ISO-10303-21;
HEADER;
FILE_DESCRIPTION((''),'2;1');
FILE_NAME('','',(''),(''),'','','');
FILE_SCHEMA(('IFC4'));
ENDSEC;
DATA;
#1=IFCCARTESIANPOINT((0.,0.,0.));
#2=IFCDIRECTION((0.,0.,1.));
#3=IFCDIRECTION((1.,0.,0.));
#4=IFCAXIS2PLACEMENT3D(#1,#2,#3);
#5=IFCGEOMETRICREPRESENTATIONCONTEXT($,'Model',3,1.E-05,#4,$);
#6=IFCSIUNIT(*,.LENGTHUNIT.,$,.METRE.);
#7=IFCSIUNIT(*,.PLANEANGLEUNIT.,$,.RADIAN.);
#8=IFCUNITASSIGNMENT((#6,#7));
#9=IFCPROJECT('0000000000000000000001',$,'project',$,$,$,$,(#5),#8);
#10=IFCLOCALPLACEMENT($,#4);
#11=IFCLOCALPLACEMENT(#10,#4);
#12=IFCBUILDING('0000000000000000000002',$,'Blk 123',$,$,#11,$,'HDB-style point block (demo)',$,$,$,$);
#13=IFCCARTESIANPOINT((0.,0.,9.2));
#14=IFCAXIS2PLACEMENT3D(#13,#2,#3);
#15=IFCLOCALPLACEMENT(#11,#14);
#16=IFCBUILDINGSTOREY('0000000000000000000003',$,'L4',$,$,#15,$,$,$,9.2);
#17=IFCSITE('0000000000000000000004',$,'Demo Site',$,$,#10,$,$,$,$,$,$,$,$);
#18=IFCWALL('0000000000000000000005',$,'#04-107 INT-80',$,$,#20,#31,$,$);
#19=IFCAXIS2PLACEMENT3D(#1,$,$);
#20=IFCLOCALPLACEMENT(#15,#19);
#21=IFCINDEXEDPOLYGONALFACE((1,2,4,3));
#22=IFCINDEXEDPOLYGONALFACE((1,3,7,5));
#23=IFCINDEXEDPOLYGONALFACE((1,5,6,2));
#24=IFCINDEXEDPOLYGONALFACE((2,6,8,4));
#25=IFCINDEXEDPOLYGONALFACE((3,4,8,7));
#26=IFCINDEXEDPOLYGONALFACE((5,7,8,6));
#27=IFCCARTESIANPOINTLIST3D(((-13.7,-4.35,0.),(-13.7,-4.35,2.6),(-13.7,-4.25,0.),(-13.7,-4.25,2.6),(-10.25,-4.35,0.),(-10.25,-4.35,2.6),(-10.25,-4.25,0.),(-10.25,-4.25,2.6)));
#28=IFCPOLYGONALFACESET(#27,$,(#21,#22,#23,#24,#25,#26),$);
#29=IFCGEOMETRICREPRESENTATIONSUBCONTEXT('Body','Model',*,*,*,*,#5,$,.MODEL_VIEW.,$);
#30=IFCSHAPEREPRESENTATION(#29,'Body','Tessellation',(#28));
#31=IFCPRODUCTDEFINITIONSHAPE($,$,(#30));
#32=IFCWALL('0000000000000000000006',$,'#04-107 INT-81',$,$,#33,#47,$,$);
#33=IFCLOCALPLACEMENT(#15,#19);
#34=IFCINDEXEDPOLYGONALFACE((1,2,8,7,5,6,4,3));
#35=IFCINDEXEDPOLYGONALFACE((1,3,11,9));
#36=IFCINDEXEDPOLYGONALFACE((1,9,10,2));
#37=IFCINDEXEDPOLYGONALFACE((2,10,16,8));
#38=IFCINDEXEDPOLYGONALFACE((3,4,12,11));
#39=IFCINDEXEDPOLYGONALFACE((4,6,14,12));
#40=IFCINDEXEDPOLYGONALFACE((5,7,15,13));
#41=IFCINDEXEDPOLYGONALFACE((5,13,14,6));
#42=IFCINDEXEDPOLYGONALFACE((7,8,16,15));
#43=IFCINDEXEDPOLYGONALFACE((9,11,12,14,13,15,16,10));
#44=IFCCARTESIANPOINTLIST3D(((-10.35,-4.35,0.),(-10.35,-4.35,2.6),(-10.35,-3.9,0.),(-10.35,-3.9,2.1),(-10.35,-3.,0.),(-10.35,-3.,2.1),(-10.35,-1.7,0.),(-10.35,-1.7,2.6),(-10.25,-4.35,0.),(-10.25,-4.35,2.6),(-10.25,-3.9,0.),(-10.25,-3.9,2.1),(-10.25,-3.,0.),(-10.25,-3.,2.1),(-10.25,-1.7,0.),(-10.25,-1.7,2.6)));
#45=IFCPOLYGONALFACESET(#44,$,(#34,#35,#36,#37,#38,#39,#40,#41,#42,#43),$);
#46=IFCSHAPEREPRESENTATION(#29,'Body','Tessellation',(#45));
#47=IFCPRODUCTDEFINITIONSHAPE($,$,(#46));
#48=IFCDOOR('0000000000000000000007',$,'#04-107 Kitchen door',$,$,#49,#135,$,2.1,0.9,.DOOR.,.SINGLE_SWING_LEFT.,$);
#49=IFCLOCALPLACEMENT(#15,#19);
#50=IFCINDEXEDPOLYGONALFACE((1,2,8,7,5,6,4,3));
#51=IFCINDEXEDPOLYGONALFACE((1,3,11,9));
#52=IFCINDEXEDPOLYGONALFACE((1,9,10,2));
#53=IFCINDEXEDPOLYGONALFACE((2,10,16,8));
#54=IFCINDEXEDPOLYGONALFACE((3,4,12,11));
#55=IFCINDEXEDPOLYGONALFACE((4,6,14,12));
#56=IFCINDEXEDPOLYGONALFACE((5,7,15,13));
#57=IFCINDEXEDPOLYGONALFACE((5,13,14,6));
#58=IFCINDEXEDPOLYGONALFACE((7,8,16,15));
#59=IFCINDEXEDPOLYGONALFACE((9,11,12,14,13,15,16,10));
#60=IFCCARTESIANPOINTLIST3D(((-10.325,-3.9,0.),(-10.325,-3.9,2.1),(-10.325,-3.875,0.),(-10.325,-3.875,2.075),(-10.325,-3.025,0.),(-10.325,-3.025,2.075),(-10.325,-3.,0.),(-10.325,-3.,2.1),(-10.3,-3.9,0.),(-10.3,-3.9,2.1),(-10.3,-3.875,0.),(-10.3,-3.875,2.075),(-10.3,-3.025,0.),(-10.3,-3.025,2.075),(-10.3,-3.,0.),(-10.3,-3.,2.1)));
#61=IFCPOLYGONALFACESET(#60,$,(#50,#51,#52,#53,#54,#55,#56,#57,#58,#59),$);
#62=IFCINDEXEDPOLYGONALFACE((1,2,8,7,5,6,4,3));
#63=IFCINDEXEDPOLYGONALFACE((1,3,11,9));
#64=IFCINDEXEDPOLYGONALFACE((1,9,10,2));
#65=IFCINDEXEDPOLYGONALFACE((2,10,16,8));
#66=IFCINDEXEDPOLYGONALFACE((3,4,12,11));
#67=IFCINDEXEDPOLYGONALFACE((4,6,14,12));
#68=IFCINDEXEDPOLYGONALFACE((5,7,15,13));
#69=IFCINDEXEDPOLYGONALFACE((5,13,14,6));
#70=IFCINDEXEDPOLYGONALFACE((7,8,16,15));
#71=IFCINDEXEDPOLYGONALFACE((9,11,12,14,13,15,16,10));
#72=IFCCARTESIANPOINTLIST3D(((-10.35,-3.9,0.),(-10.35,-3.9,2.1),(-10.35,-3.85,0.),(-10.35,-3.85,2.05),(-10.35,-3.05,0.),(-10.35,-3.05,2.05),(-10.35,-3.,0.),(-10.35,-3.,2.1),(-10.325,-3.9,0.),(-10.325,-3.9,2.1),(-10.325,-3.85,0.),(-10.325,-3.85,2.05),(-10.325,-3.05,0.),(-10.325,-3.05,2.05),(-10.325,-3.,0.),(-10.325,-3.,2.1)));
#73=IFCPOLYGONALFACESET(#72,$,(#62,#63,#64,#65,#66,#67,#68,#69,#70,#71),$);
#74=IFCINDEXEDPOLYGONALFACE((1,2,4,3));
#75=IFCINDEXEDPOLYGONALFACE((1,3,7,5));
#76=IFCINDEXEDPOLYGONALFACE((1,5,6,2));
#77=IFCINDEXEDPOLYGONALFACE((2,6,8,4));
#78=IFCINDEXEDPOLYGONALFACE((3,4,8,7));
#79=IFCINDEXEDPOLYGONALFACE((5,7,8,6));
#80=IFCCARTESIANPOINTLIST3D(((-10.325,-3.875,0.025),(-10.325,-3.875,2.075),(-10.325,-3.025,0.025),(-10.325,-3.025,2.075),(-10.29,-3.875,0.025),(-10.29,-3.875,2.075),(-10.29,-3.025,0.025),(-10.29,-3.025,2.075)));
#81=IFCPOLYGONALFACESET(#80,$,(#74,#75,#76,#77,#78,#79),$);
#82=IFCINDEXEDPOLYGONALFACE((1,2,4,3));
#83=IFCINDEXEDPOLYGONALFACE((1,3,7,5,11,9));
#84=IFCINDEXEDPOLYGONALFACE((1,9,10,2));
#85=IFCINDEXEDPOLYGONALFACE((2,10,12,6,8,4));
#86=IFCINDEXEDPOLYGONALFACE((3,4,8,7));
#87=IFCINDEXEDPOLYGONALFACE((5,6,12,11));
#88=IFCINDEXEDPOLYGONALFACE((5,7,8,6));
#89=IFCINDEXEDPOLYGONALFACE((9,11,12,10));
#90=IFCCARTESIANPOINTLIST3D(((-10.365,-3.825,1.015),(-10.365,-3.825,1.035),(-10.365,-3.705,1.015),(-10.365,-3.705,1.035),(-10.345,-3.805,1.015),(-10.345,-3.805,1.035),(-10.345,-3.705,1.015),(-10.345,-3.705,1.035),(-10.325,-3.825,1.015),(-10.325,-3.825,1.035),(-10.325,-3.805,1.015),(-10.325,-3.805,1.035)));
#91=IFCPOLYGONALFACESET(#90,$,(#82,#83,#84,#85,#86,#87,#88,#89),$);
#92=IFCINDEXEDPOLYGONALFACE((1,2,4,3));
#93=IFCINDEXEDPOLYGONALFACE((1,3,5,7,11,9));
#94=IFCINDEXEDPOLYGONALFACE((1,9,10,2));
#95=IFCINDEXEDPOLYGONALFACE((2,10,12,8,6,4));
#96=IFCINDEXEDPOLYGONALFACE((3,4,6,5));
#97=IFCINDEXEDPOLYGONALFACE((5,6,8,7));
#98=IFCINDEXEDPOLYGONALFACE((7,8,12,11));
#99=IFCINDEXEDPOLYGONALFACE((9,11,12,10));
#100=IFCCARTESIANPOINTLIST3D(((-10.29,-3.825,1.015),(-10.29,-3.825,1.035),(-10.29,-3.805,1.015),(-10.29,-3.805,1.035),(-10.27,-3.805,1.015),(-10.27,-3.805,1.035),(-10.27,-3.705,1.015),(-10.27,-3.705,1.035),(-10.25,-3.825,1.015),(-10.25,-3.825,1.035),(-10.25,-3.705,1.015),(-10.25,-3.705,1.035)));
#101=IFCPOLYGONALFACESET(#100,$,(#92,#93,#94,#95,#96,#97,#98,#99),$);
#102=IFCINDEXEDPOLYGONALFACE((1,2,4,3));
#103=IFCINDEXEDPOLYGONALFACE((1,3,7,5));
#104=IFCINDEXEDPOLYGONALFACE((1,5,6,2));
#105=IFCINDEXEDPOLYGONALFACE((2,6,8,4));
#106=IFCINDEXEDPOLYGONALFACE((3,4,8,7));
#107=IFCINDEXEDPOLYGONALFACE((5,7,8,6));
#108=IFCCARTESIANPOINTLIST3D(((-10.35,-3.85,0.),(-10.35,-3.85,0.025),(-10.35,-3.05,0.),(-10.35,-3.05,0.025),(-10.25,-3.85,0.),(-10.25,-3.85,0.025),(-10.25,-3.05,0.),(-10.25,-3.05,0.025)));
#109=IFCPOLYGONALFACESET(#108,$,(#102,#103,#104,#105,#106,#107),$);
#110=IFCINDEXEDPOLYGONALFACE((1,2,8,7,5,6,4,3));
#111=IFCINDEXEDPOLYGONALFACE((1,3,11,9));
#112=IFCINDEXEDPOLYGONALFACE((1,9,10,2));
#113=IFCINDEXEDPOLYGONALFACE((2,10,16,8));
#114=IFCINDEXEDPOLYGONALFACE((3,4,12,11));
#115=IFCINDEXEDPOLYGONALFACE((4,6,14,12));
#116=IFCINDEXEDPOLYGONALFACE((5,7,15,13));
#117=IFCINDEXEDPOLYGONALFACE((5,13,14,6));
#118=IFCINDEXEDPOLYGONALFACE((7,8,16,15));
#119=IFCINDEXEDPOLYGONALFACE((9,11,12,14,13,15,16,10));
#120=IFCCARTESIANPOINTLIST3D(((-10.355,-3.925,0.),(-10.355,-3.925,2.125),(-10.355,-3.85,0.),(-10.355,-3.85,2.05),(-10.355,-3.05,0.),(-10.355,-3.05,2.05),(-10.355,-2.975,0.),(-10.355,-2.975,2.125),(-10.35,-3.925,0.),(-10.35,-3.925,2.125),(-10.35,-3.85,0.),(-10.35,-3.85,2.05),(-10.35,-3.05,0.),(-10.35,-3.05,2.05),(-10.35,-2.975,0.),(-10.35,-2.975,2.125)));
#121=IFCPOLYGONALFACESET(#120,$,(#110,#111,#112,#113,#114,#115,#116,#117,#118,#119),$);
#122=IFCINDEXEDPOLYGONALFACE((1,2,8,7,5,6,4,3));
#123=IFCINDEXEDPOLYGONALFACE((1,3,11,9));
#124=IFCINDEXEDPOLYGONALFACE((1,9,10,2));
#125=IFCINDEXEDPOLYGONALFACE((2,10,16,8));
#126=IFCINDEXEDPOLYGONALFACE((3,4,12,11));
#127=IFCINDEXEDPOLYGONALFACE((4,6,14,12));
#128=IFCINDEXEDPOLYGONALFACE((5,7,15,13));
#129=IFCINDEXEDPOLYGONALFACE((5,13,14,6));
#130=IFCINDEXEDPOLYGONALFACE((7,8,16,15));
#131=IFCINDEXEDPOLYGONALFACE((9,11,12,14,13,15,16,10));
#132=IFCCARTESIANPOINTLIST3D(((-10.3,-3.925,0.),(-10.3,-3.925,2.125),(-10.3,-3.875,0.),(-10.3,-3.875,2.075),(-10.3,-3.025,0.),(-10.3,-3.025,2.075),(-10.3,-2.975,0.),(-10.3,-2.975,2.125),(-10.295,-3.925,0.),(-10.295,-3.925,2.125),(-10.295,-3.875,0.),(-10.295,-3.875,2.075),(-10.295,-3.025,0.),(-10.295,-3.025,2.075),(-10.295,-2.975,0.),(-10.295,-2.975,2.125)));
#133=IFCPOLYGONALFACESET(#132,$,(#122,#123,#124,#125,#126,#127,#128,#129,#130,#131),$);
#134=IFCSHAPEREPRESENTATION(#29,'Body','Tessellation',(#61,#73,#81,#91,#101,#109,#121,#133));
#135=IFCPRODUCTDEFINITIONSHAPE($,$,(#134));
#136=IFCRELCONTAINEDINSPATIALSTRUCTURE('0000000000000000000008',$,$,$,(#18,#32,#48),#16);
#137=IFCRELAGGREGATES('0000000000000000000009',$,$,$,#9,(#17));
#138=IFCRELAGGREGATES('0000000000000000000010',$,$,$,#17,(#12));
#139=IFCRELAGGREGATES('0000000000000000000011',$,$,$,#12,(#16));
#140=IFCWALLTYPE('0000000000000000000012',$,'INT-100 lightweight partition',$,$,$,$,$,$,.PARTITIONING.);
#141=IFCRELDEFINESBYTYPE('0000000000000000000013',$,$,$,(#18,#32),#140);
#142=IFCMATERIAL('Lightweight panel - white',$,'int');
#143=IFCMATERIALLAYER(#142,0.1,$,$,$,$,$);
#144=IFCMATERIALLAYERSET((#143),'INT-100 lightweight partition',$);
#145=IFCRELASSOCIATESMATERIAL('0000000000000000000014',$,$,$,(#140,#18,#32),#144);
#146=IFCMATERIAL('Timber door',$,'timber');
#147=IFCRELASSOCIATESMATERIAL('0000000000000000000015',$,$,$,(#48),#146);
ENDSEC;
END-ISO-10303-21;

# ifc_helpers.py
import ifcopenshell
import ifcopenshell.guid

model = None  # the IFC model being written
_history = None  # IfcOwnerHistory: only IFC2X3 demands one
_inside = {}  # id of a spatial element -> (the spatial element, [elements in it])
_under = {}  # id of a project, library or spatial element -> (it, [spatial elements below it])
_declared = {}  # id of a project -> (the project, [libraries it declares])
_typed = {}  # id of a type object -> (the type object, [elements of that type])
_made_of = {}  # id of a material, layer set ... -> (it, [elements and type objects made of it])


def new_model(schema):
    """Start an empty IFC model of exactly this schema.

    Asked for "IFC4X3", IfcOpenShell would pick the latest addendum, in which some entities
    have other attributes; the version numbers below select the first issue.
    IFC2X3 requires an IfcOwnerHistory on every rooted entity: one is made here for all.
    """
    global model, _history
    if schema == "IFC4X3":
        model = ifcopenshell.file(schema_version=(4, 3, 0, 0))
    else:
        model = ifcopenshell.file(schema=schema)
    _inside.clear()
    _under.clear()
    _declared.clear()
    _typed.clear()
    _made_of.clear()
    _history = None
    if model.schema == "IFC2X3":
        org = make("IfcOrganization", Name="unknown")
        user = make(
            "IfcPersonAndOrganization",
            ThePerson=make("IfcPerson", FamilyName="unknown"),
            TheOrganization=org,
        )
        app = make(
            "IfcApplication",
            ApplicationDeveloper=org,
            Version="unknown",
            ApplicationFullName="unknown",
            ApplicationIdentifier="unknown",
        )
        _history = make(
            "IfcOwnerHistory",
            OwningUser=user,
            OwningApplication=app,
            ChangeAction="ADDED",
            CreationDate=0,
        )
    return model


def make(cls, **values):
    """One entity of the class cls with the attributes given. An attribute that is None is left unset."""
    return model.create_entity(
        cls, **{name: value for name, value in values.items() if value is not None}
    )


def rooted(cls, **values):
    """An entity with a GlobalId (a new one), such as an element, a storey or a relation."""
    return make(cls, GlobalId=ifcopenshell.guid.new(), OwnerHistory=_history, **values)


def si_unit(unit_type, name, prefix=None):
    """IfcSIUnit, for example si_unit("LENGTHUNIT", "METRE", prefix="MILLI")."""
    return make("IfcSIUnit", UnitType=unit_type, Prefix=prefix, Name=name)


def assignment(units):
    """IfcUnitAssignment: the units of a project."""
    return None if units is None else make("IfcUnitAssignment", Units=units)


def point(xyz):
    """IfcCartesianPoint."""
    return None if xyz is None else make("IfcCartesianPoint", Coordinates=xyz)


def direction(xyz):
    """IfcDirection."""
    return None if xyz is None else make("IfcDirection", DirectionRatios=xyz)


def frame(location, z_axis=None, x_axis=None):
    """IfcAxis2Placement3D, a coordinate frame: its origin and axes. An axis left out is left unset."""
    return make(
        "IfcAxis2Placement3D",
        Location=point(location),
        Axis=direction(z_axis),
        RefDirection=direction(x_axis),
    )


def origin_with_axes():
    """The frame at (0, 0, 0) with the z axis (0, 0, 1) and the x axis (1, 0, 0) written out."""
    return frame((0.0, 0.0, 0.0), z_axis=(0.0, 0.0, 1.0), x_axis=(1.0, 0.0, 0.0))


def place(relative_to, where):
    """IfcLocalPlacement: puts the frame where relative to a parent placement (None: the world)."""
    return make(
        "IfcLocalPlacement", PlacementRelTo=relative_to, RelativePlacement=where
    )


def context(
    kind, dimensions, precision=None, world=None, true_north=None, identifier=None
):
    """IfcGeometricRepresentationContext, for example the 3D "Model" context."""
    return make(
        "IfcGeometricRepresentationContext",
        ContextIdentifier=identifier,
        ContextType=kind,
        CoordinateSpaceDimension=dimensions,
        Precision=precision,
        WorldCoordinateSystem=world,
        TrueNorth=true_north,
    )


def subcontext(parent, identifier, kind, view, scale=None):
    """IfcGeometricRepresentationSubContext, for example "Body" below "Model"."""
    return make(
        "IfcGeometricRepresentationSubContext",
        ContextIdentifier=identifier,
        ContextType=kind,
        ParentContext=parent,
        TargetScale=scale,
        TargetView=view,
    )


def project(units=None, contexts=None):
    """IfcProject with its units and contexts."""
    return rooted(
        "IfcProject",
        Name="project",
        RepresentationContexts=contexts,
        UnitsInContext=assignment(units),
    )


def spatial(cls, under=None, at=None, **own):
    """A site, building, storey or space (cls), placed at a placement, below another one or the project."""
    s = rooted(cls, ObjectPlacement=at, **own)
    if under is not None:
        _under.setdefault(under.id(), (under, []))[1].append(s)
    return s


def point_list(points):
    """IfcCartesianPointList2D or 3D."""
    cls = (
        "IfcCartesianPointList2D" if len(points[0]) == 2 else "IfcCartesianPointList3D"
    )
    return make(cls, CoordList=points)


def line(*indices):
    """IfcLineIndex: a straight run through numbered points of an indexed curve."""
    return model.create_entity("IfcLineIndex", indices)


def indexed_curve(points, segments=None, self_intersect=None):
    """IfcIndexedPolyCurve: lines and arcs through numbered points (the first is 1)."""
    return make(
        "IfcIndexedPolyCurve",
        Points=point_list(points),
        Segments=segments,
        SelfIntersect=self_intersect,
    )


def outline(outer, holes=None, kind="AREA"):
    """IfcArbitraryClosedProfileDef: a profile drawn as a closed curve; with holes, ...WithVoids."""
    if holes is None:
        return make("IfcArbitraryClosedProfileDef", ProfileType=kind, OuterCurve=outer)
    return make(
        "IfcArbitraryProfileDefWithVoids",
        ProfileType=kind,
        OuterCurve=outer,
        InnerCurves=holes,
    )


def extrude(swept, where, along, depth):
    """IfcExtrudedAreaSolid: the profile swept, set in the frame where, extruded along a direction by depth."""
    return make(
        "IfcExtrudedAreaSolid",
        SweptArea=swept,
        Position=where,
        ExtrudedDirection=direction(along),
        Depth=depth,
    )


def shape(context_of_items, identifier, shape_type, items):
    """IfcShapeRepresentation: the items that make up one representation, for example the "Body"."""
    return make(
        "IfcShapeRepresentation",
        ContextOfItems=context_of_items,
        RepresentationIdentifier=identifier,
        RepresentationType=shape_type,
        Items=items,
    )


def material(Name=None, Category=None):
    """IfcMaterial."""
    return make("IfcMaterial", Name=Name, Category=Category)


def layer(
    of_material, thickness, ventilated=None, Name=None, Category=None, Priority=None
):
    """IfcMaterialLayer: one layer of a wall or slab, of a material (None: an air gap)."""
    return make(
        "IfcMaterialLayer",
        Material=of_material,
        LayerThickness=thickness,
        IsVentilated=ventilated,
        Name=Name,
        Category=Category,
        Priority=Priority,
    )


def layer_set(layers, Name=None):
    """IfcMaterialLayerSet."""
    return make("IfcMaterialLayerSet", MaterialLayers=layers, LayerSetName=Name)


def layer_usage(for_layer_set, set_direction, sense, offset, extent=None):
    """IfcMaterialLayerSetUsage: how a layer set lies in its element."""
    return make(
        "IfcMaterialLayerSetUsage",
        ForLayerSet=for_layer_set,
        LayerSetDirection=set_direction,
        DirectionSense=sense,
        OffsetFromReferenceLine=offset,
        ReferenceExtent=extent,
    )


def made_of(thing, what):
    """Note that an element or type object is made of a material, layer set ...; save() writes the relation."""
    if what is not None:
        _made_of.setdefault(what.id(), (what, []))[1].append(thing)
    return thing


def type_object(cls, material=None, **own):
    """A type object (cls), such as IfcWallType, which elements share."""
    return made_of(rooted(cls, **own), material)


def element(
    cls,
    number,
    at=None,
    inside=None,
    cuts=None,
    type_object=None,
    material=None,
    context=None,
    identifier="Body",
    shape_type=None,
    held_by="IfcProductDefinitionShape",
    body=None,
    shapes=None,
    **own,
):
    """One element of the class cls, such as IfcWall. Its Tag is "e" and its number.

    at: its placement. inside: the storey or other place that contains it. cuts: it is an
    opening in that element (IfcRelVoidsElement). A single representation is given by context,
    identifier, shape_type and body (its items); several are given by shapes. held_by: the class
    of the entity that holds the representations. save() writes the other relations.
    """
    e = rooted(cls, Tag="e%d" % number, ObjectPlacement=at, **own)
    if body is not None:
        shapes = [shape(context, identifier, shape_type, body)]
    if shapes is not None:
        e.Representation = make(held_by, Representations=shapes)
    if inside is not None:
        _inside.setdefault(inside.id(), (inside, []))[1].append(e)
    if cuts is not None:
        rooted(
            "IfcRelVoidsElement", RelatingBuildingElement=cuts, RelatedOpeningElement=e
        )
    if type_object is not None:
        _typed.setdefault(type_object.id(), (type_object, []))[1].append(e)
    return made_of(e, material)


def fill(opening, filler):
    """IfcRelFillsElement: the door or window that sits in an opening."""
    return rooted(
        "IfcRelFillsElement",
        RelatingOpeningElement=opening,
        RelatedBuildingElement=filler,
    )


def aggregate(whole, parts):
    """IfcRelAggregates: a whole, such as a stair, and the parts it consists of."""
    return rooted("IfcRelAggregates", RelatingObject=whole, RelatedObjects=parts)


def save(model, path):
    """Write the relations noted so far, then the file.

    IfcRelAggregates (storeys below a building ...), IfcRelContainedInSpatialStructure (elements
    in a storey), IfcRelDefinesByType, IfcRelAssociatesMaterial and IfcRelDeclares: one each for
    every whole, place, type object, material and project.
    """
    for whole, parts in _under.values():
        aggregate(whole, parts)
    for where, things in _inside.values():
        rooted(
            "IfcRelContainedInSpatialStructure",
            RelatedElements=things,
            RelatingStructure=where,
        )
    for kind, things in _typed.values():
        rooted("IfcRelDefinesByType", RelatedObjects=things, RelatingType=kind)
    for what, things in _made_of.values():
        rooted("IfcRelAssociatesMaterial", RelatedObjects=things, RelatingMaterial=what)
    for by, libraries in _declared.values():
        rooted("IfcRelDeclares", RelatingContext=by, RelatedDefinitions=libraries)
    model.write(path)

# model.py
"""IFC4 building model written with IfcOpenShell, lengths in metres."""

from ifc_helpers import new_model, si_unit, frame, origin_with_axes, place, context, subcontext, project, spatial, line, indexed_curve, outline, extrude, material, layer, layer_set, layer_usage, type_object, element, fill, save


model = new_model("IFC4")

# Units and contexts
model_context = context("Model", 3, precision=1e-05, world=origin_with_axes())
body_context = subcontext(model_context, "Body", "Model", "MODEL_VIEW")
ifc_project = project(units=[si_unit("LENGTHUNIT", "METRE"), si_unit("PLANEANGLEUNIT", "RADIAN")], contexts=[model_context])

# Site, building, storey
site_placement = place(None, origin_with_axes())
site = spatial("IfcSite", under=ifc_project, at=site_placement, Name="Demo Site")
building_placement = place(site_placement, origin_with_axes())
building = spatial("IfcBuilding", under=site, at=building_placement, Name="Blk 123", LongName="HDB-style point block (demo)")
storey_placement = place(building_placement, frame((0.0, 0.0, 9.2), z_axis=(0.0, 0.0, 1.0), x_axis=(1.0, 0.0, 0.0)))
storey = spatial("IfcBuildingStorey", under=building, at=storey_placement, Name="L4", Elevation=9.2)

# Wall
ifc_material_1 = material(Name="Lightweight panel - white", Category="int")
ifc_layer_1 = layer(ifc_material_1, 0.1)
ifc_layer_set_1 = layer_set([ifc_layer_1], Name="INT-100 lightweight partition")
ifc_layer_usage_1 = layer_usage(ifc_layer_set_1, "AXIS2", "POSITIVE", -0.05)
wall_type_1 = type_object("IfcWallType", Name="INT-100 lightweight partition", PredefinedType="PARTITIONING", material=ifc_layer_set_1)
wall_1_placement = place(storey_placement, frame((-10.25, -4.3, 0.0), z_axis=(0.0, 0.0, 1.0), x_axis=(-1.0, 0.0, 0.0)))
element("IfcWall", 1, at=wall_1_placement, inside=storey, type_object=wall_type_1, material=ifc_layer_usage_1, Name="#04-107 INT-80", context=body_context, shape_type="SweptSolid", body=[
    extrude(outline(indexed_curve([(0.0, 0.0), (0.0, 0.1), (3.45, 0.1), (3.45, 0.0), (0.0, 0.0)], self_intersect=False)), frame((0.0, -0.05, 0.0), z_axis=(0.0, 0.0, 1.0), x_axis=(1.0, 0.0, 0.0)), (0.0, 0.0, 1.0), 2.6),
])

# Wall, opening, door
wall_2_placement = place(storey_placement, frame((-10.3, -1.7, 0.0), z_axis=(0.0, 0.0, 1.0), x_axis=(0.0, -1.0, 0.0)))
wall_2 = element("IfcWall", 2, at=wall_2_placement, inside=storey, type_object=wall_type_1, material=ifc_layer_usage_1, Name="#04-107 INT-81", context=body_context, shape_type="SweptSolid", body=[
    extrude(outline(indexed_curve([(0.0, 0.0), (0.0, 0.1), (2.65, 0.1), (2.65, 0.0), (0.0, 0.0)], self_intersect=False)), frame((0.0, -0.05, 0.0), z_axis=(0.0, 0.0, 1.0), x_axis=(1.0, 0.0, 0.0)), (0.0, 0.0, 1.0), 2.6),
])
opening_1_placement = place(wall_2_placement, frame((1.3, -0.15, 0.0), z_axis=(0.0, 0.0, 1.0), x_axis=(1.0, 0.0, 0.0)))
opening_1 = element("IfcOpeningElement", 3, at=opening_1_placement, cuts=wall_2, context=body_context, shape_type="SweptSolid", body=[
    extrude(outline(indexed_curve([(0.0, 0.0), (0.0, 0.3), (0.9, 0.3), (0.9, 0.0), (0.0, 0.0)], self_intersect=False)), origin_with_axes(), (0.0, 0.0, 1.0), 2.1),
])
ifc_material_2 = material(Name="Timber door", Category="timber")
door_1_placement = place(opening_1_placement, frame((0.0, 0.1, 0.0), z_axis=(0.0, 0.0, 1.0), x_axis=(1.0, 0.0, 0.0)))
door_1 = element("IfcDoor", 4, at=door_1_placement, inside=storey, material=ifc_material_2, Name="#04-107 Kitchen door", OperationType="SINGLE_SWING_LEFT", OverallHeight=2.1, OverallWidth=0.9, PredefinedType="DOOR", context=body_context, shape_type="SweptSolid", body=[
    extrude(outline(indexed_curve([(0.0, 0.0), (0.0, 2.1), (0.9, 2.1), (0.9, 0.0), (0.875, 0.0), (0.875, 2.075), (0.025, 2.075), (0.025, 0.0)], segments=[line(1, 2, 3, 4, 5, 6, 7, 8, 1)])), frame((0.0, 0.025, 0.0), z_axis=(0.0, -1.0, 0.0), x_axis=(1.0, 0.0, 0.0)), (0.0, 0.0, -1.0), 0.025),
    extrude(outline(indexed_curve([(0.0, 0.0), (0.0, 2.1), (0.9, 2.1), (0.9, 0.0), (0.85, 0.0), (0.85, 2.05), (0.05, 2.05), (0.05, 0.0)], segments=[line(1, 2, 3, 4, 5, 6, 7, 8, 1)])), frame((0.0, 0.0, 0.0), z_axis=(0.0, -1.0, 0.0), x_axis=(1.0, 0.0, 0.0)), (0.0, 0.0, -1.0), 0.025),
    extrude(outline(indexed_curve([(0.0, 0.0), (0.85, 0.0), (0.85, 0.035), (0.0, 0.035)], segments=[line(1, 2, 3, 4, 1)])), frame((0.025, 0.025, 0.025), z_axis=(0.0, 0.0, 1.0), x_axis=(1.0, 0.0, 0.0)), (0.0, 0.0, 1.0), 2.05),
    extrude(outline(indexed_curve([(0.0, 0.0), (0.0, -0.04), (-0.12, -0.04), (-0.12, -0.02), (-0.02, -0.02), (-0.02, 0.0)], segments=[line(1, 2, 3, 4, 5, 6, 1)])), frame((0.825, 0.025, 1.015), z_axis=(0.0, 0.0, 1.0), x_axis=(1.0, 0.0, 0.0)), (0.0, 0.0, 1.0), 0.02),
    extrude(outline(indexed_curve([(0.0, 0.0), (0.0, 0.04), (-0.12, 0.04), (-0.12, 0.02), (-0.02, 0.02), (-0.02, 0.0)], segments=[line(1, 2, 3, 4, 5, 6, 1)])), frame((0.825, 0.06, 1.015), z_axis=(0.0, 0.0, 1.0), x_axis=(1.0, 0.0, 0.0)), (0.0, 0.0, 1.0), 0.02),
    extrude(outline(indexed_curve([(0.0, 0.0), (0.8, 0.0), (0.8, 0.1), (0.0, 0.1)], segments=[line(1, 2, 3, 4, 1)])), frame((0.05, 0.0, 0.0), z_axis=(0.0, 0.0, 1.0), x_axis=(1.0, 0.0, 0.0)), (0.0, 0.0, 1.0), 0.025),
    extrude(outline(indexed_curve([(0.0, 0.0), (0.0, 2.125), (0.95, 2.125), (0.95, 0.0), (0.875, 0.0), (0.875, 2.05), (0.075, 2.05), (0.075, 0.0)], segments=[line(1, 2, 3, 4, 5, 6, 7, 8, 1)])), frame((-0.025, -0.005, 0.0), z_axis=(0.0, -1.0, 0.0), x_axis=(1.0, 0.0, 0.0)), (0.0, 0.0, -1.0), 0.005),
    extrude(outline(indexed_curve([(0.0, 0.0), (0.0, 2.125), (0.95, 2.125), (0.95, 0.0), (0.9, 0.0), (0.9, 2.075), (0.05, 2.075), (0.05, 0.0)], segments=[line(1, 2, 3, 4, 5, 6, 7, 8, 1)])), frame((-0.025, 0.05, 0.0), z_axis=(0.0, -1.0, 0.0), x_axis=(1.0, 0.0, 0.0)), (0.0, 0.0, -1.0), 0.005),
])
fill(opening_1, door_1)

save(model, "model.ifc")
